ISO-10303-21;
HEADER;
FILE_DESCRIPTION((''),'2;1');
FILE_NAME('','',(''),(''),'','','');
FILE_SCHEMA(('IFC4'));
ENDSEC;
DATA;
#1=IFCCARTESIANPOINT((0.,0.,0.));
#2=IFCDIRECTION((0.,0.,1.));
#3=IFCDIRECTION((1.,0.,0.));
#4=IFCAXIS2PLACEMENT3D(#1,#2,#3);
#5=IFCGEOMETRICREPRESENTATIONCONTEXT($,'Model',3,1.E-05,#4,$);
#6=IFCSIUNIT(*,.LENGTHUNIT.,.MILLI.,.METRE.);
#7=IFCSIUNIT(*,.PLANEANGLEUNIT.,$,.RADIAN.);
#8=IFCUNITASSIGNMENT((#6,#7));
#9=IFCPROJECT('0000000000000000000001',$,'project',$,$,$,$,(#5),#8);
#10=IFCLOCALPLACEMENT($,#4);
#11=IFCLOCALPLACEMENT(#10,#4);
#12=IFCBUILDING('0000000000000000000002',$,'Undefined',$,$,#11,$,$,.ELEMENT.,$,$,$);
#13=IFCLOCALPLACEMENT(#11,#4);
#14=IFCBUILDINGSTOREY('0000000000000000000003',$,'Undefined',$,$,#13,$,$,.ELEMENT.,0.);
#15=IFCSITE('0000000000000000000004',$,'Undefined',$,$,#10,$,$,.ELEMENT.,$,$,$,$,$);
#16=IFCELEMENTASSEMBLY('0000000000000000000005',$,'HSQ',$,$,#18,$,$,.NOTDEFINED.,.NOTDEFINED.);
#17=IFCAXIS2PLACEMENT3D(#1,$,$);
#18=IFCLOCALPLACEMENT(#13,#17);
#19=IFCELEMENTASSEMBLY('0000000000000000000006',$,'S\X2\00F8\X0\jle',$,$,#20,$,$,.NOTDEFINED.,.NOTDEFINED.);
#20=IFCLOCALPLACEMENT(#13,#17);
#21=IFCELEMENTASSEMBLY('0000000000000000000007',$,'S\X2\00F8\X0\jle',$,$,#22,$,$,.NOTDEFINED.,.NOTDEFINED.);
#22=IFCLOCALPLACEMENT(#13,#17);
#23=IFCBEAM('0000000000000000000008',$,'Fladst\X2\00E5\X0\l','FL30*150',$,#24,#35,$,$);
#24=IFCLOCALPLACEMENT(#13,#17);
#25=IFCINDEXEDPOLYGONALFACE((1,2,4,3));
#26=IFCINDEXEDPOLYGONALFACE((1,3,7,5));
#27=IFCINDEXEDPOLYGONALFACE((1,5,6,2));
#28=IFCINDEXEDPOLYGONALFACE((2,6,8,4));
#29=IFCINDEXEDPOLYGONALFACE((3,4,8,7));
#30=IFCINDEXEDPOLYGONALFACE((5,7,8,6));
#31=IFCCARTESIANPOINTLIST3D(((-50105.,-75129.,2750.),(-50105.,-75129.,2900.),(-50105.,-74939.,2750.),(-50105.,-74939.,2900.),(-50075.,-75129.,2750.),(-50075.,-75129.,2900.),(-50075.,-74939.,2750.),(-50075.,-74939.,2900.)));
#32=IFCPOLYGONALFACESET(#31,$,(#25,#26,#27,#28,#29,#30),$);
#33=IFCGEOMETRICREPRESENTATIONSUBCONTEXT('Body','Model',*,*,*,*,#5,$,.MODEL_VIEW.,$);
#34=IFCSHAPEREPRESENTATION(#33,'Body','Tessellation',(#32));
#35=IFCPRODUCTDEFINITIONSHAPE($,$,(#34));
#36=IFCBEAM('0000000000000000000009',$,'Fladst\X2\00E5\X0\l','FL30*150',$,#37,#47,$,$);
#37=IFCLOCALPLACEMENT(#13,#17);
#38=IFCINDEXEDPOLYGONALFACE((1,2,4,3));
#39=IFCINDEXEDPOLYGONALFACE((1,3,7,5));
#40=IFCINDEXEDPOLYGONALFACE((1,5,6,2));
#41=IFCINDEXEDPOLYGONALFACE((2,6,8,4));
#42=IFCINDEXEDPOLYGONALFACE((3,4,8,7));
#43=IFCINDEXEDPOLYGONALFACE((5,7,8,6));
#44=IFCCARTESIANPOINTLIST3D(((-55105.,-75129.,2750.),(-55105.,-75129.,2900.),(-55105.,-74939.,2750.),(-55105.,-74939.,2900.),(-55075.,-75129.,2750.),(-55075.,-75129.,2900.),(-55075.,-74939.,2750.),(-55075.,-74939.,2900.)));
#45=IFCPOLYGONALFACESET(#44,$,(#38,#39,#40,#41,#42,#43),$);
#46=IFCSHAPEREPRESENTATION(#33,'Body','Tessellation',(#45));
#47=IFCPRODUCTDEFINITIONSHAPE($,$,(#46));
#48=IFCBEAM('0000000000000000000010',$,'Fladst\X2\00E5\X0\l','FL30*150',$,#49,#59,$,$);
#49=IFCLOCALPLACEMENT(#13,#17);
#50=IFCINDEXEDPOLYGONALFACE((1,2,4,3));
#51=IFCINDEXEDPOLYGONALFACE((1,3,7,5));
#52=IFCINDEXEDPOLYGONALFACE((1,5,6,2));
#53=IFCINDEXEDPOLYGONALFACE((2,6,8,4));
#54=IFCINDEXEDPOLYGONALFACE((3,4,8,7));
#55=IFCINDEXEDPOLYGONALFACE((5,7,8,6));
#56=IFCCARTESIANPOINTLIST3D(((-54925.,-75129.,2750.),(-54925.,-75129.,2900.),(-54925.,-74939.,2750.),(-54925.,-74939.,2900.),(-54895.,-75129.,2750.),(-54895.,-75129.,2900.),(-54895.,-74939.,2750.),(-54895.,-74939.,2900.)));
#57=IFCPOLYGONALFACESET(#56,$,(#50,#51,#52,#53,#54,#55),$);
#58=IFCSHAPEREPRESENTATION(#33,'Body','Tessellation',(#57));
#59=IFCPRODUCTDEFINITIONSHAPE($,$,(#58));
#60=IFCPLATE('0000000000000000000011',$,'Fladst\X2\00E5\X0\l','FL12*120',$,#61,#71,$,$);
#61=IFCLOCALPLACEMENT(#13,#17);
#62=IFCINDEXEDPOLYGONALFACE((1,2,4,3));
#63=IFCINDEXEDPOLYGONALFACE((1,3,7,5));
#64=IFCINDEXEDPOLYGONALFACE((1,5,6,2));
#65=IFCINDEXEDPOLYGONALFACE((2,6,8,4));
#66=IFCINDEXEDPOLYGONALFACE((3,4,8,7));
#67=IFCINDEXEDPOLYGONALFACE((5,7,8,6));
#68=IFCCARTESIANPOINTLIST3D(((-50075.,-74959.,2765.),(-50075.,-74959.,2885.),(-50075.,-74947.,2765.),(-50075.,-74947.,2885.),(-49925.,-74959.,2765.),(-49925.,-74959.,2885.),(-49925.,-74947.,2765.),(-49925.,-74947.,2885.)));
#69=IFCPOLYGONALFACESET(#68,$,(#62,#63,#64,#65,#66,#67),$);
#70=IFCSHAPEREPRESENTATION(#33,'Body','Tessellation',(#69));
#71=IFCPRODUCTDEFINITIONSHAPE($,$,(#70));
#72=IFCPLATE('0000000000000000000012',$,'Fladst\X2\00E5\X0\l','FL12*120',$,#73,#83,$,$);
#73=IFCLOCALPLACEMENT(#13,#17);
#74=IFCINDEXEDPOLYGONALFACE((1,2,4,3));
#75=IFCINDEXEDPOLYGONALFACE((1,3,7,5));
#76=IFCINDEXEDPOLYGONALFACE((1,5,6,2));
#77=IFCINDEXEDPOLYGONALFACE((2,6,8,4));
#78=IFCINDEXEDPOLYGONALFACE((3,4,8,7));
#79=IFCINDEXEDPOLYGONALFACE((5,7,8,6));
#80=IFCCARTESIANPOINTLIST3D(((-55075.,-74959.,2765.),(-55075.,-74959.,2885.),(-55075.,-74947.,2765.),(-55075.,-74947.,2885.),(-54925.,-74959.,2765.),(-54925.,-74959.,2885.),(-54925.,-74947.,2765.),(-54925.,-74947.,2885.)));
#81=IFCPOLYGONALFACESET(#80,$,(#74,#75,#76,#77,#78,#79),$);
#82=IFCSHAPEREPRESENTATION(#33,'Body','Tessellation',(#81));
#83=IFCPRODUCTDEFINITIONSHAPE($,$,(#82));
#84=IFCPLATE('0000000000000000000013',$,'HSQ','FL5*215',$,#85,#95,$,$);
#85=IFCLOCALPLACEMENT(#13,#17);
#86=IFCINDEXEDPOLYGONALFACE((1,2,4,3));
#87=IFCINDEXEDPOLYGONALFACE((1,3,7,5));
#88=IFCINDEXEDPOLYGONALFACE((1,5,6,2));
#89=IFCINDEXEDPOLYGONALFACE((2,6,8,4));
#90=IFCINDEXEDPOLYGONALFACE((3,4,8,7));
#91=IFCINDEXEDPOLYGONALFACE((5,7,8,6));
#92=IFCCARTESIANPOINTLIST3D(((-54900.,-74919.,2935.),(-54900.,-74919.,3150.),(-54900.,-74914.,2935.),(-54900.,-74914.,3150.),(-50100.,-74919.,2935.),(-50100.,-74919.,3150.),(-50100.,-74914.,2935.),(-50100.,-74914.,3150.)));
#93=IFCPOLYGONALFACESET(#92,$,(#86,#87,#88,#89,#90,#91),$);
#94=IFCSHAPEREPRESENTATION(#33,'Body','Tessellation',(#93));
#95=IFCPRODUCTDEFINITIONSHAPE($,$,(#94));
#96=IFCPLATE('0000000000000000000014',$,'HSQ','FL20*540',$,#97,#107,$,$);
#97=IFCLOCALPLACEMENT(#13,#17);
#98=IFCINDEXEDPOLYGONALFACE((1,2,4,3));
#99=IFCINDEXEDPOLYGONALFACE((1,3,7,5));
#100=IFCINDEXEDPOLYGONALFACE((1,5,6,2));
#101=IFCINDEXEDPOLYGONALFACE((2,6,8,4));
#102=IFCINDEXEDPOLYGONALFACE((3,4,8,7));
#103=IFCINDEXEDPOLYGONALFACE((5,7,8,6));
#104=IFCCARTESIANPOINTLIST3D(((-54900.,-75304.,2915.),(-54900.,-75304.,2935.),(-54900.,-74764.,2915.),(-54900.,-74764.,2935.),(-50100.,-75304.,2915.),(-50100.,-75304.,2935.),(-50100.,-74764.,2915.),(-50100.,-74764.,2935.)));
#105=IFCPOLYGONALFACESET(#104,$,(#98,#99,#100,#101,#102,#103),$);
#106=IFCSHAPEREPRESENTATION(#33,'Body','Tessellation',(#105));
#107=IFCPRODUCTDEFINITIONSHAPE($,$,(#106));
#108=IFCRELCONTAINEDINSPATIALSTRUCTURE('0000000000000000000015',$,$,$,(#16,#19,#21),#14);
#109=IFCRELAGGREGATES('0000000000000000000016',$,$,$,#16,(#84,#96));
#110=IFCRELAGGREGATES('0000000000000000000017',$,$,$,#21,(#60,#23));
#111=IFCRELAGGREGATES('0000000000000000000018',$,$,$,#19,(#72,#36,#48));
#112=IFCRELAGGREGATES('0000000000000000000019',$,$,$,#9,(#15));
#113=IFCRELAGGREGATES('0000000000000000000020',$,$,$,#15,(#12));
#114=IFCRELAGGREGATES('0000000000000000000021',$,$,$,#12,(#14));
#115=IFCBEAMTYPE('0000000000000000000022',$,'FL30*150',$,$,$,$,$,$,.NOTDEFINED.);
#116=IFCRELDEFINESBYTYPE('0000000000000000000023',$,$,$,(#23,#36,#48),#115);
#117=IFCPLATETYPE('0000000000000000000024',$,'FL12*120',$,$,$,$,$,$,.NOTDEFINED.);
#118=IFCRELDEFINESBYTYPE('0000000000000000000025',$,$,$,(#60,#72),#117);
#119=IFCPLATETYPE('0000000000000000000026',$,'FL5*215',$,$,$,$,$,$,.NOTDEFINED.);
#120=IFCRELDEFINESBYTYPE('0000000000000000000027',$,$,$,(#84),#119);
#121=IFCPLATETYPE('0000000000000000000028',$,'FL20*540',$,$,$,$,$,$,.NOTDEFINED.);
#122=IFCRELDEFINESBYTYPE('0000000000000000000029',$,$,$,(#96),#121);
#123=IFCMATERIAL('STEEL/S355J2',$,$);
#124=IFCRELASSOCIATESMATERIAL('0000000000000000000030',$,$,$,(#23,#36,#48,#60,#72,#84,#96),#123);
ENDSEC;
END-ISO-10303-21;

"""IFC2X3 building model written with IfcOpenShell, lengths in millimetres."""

from ifc_helpers import new_model, si_unit, frame, origin_with_axes, origin_2d_with_axis, place, context, subcontext, project, spatial, polyline, rectangle, outline, extrude, material, type_object, element, aggregate, save


model = new_model("IFC2X3")

# Units and contexts
model_context = context("Model", 3, precision=1e-05, world=origin_with_axes())
body_context = subcontext(model_context, "Body", "Model", "MODEL_VIEW")
ifc_project = project(units=[si_unit("LENGTHUNIT", "METRE", prefix="MILLI"), si_unit("PLANEANGLEUNIT", "RADIAN")], contexts=[model_context])

# Site, building, storey
site_placement = place(None, origin_with_axes())
site = spatial("IfcSite", under=ifc_project, at=site_placement, Name="Undefined", CompositionType="ELEMENT")
building_placement = place(site_placement, origin_with_axes())
building = spatial("IfcBuilding", under=site, at=building_placement, Name="Undefined", CompositionType="ELEMENT")
storey_placement = place(building_placement, origin_with_axes())
storey = spatial("IfcBuildingStorey", under=building, at=storey_placement, Name="Undefined", CompositionType="ELEMENT", Elevation=0.0)

# Element assembly
assembly_1_placement = place(storey_placement, origin_with_axes())
assembly_1 = element("IfcElementAssembly", 1, at=assembly_1_placement, inside=storey, Name="HSQ", AssemblyPlace="NOTDEFINED", PredefinedType="NOTDEFINED")

# Element assembly
assembly_2_placement = place(storey_placement, origin_with_axes())
assembly_2 = element("IfcElementAssembly", 2, at=assembly_2_placement, inside=storey, Name="Søjle", AssemblyPlace="NOTDEFINED", PredefinedType="NOTDEFINED")

# Element assembly, beam
assembly_3_placement = place(storey_placement, origin_with_axes())
assembly_3 = element("IfcElementAssembly", 3, at=assembly_3_placement, inside=storey, Name="Søjle", AssemblyPlace="NOTDEFINED", PredefinedType="NOTDEFINED")
ifc_material_1 = material(Name="STEEL/S355J2")
beam_type = type_object("IfcBeamType", Name="FL30*150", PredefinedType="NOTDEFINED")
beam_1_placement = place(assembly_3_placement, frame((-50090.0, -75034.0, 2900.0), z_axis=(0.0, -1.0, 0.0), x_axis=(0.0, 0.0, -1.0)))
beam_1 = element("IfcBeam", 4, at=beam_1_placement, type_object=beam_type, material=ifc_material_1, Name="Fladstål", Description="FL30*150", context=body_context, shape_type="SweptSolid", body=[
    extrude(rectangle(XDim=30.0, YDim=190.0, at=origin_2d_with_axis()), frame((150.0, 0.0, 0.0), z_axis=(-1.0, 0.0, 0.0), x_axis=(0.0, -1.0, 0.0)), (0.0, 0.0, 1.0), 150.0),
])

# Beams
beam_2_placement = place(assembly_2_placement, frame((-55090.0, -75034.0, 2900.0), z_axis=(0.0, -1.0, 0.0), x_axis=(0.0, 0.0, -1.0)))
beam_2 = element("IfcBeam", 5, at=beam_2_placement, type_object=beam_type, material=ifc_material_1, Name="Fladstål", Description="FL30*150", context=body_context, shape_type="SweptSolid", body=[
    extrude(rectangle(XDim=30.0, YDim=190.0, at=origin_2d_with_axis()), frame((150.0, 0.0, 0.0), z_axis=(-1.0, 0.0, 0.0), x_axis=(0.0, -1.0, 0.0)), (0.0, 0.0, 1.0), 150.0),
])
beam_3_placement = place(assembly_2_placement, frame((-54910.0, -75034.0, 2900.0), z_axis=(0.0, -1.0, 0.0), x_axis=(0.0, 0.0, -1.0)))
beam_3 = element("IfcBeam", 6, at=beam_3_placement, type_object=beam_type, material=ifc_material_1, Name="Fladstål", Description="FL30*150", context=body_context, shape_type="SweptSolid", body=[
    extrude(rectangle(XDim=30.0, YDim=190.0, at=origin_2d_with_axis()), frame((150.0, 0.0, 0.0), z_axis=(-1.0, 0.0, 0.0), x_axis=(0.0, -1.0, 0.0)), (0.0, 0.0, 1.0), 150.0),
])

# Plates
plate_type_1 = type_object("IfcPlateType", Name="FL12*120", PredefinedType="NOTDEFINED")
plate_1_placement = place(assembly_3_placement, frame((-49925.0, -74953.0, 2885.0), z_axis=(0.0, -1.0, 0.0), x_axis=(-1.0, 0.0, 0.0)))
plate_1 = element("IfcPlate", 7, at=plate_1_placement, type_object=plate_type_1, material=ifc_material_1, Name="Fladstål", Description="FL12*120", context=body_context, shape_type="SweptSolid", body=[
    extrude(outline(polyline([(0.0, 0.0), (150.0, 0.0), (150.0, 120.0), (0.0, 120.0), (0.0, 0.0)])), frame((0.0, 0.0, -6.0), z_axis=(0.0, 0.0, 1.0), x_axis=(1.0, 0.0, 0.0)), (0.0, 0.0, 1.0), 12.0),
])
plate_2_placement = place(assembly_2_placement, frame((-54925.0, -74953.0, 2885.0), z_axis=(0.0, -1.0, 0.0), x_axis=(-1.0, 0.0, 0.0)))
plate_2 = element("IfcPlate", 8, at=plate_2_placement, type_object=plate_type_1, material=ifc_material_1, Name="Fladstål", Description="FL12*120", context=body_context, shape_type="SweptSolid", body=[
    extrude(outline(polyline([(0.0, 0.0), (150.0, 0.0), (150.0, 120.0), (0.0, 120.0), (0.0, 0.0)])), frame((0.0, 0.0, -6.0), z_axis=(0.0, 0.0, 1.0), x_axis=(1.0, 0.0, 0.0)), (0.0, 0.0, 1.0), 12.0),
])
plate_type_2 = type_object("IfcPlateType", Name="FL5*215", PredefinedType="NOTDEFINED")
plate_3_placement = place(assembly_1_placement, frame((-54900.0, -74916.5, 3042.5), z_axis=(0.0, -1.0, 0.0), x_axis=(1.0, 0.0, 0.0)))
plate_3 = element("IfcPlate", 9, at=plate_3_placement, type_object=plate_type_2, material=ifc_material_1, Name="HSQ", Description="FL5*215", context=body_context, shape_type="SweptSolid", body=[
    extrude(outline(polyline([(0.0, -107.5), (0.0, 107.5), (4800.0, 107.5), (4800.0, -107.5), (0.0, -107.5)])), frame((0.0, 0.0, -2.5), z_axis=(0.0, 0.0, 1.0), x_axis=(1.0, 0.0, 0.0)), (0.0, 0.0, 1.0), 5.0),
])
plate_type_3 = type_object("IfcPlateType", Name="FL20*540", PredefinedType="NOTDEFINED")
plate_4_placement = place(assembly_1_placement, frame((-54900.0, -75034.0, 2925.0), z_axis=(0.0, 0.0, 1.0), x_axis=(1.0, 0.0, 0.0)))
plate_4 = element("IfcPlate", 10, at=plate_4_placement, type_object=plate_type_3, material=ifc_material_1, Name="HSQ", Description="FL20*540", context=body_context, shape_type="SweptSolid", body=[
    extrude(outline(polyline([(0.0, -270.0), (0.0, 270.0), (4800.0, 270.0), (4800.0, -270.0), (0.0, -270.0)])), frame((0.0, 0.0, -10.0), z_axis=(0.0, 0.0, 1.0), x_axis=(1.0, 0.0, 0.0)), (0.0, 0.0, 1.0), 20.0),
])
aggregate(assembly_1, [plate_3, plate_4])

aggregate(assembly_3, [plate_1, beam_1])
aggregate(assembly_2, [plate_2, beam_2, beam_3])

save(model, "model.ifc")
